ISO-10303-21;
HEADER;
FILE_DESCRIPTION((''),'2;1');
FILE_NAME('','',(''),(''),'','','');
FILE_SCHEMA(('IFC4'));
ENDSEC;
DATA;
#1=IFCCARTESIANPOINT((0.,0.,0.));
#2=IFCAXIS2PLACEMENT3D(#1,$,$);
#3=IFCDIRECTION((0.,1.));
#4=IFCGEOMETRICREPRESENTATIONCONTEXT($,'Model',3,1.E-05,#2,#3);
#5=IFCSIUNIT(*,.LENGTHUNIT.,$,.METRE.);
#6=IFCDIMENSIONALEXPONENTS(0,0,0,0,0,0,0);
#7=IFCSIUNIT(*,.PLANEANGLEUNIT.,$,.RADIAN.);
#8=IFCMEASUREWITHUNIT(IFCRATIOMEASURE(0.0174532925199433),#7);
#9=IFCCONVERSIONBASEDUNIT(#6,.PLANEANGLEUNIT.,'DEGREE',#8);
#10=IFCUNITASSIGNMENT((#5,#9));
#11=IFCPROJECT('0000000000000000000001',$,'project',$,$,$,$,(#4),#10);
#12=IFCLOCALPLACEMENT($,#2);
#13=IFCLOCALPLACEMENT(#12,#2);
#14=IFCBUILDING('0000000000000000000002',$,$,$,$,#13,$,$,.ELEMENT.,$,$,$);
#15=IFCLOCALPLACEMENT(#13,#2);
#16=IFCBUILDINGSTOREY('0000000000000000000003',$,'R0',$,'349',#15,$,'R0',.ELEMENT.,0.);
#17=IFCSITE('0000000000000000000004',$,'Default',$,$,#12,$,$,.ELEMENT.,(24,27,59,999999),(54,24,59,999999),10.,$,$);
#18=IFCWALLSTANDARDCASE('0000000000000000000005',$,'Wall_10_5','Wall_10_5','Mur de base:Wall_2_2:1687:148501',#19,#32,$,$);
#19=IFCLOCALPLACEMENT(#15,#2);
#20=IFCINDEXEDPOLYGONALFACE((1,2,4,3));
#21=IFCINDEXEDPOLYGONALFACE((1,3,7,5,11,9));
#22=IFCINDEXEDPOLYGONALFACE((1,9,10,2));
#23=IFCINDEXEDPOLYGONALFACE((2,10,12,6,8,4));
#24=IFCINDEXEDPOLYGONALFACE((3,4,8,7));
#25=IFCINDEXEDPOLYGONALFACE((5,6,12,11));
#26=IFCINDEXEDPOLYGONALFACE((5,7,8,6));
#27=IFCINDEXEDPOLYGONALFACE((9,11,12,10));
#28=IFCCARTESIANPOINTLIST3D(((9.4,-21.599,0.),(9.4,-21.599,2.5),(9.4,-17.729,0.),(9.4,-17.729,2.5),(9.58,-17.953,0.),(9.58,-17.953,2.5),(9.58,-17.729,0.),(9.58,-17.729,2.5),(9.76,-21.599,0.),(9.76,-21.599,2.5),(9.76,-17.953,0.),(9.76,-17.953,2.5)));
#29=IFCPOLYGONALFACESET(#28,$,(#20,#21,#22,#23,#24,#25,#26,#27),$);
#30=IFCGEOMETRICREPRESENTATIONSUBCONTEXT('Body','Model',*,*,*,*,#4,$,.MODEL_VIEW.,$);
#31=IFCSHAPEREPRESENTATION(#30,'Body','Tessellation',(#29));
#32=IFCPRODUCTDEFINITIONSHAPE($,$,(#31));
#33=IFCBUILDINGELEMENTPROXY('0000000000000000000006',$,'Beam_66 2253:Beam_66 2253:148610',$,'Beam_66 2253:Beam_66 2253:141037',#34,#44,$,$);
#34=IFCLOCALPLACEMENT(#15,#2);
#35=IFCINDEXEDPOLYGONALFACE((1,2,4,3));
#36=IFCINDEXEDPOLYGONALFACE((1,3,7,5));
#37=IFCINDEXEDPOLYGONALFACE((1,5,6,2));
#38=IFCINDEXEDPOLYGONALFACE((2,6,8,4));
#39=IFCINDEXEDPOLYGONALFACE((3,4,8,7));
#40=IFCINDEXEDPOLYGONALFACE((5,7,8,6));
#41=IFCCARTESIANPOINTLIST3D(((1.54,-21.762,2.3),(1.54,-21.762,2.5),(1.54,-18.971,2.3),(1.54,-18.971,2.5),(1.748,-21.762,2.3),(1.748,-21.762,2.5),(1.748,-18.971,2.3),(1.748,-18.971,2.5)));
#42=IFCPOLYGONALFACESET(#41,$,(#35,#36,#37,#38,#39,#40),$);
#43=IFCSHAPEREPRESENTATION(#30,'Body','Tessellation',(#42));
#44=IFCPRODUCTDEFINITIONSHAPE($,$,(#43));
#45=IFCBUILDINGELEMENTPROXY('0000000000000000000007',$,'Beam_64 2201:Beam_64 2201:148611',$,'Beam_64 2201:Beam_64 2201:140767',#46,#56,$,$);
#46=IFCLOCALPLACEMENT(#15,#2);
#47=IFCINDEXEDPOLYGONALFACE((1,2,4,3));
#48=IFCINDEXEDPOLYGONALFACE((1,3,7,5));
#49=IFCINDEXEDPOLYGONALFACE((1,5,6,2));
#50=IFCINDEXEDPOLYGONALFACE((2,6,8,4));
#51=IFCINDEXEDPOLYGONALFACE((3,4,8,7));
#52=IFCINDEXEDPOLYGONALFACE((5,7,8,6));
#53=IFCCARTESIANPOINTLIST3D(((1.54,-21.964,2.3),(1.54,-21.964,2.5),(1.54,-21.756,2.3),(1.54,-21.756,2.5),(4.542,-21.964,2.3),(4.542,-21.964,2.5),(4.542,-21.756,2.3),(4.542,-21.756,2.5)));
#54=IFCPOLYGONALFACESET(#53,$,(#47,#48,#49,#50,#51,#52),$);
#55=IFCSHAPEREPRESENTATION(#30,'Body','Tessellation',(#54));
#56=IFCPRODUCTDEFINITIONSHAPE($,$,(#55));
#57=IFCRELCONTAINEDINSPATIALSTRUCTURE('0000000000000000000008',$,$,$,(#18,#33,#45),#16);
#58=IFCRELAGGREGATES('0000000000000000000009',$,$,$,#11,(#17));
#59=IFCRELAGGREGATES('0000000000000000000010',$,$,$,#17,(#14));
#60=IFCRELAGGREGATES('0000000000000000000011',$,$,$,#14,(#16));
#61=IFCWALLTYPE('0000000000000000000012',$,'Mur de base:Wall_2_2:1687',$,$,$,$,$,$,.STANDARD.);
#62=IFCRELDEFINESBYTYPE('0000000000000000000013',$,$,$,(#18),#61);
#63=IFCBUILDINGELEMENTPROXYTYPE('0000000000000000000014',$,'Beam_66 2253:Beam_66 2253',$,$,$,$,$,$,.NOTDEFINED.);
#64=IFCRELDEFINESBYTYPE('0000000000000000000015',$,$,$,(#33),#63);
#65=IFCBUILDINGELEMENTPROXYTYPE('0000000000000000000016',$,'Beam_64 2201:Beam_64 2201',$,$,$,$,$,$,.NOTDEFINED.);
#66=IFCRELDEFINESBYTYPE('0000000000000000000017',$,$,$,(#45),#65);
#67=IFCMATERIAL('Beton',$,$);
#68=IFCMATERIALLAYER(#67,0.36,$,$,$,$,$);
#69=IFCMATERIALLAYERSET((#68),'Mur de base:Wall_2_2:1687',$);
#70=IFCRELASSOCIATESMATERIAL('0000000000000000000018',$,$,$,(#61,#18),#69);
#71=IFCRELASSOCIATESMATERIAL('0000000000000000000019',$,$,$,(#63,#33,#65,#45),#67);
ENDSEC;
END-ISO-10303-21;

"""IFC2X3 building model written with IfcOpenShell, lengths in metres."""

from ifc_helpers import new_model, entity, si_unit, converted_unit, direction, frame, origin, origin_2d_with_axis, place, context, subcontext, project, spatial, polyline, rectangle, outline, extrude, source, transform, mapped, material, layer, layer_set, layer_usage, type_object, type_shapes, element, save


model = new_model("IFC2X3")

# Units and contexts
model_context = context("Model", 3, precision=1e-05, world=origin(), true_north=direction((0.0, 1.0)))
body_context = subcontext(model_context, "Body", "Model", "MODEL_VIEW")
ifc_project = project(units=[si_unit("LENGTHUNIT", "METRE"), converted_unit("PLANEANGLEUNIT", "DEGREE", entity("IfcRatioMeasure", 0.0174532925199433), si_unit("PLANEANGLEUNIT", "RADIAN"), dimensions=[0, 0, 0, 0, 0, 0, 0])], contexts=[model_context])

# Site, building, storey
site_placement = place(None, origin())
site = spatial("IfcSite", under=ifc_project, at=site_placement, Name="Default", CompositionType="ELEMENT", RefLatitude=(24, 27, 59, 999999), RefLongitude=(54, 24, 59, 999999), RefElevation=10.0)
building_placement = place(site_placement, origin())
building = spatial("IfcBuilding", under=site, at=building_placement, CompositionType="ELEMENT")
storey_placement = place(building_placement, origin())
storey = spatial("IfcBuildingStorey", under=building, at=storey_placement, Name="R0", ObjectType="349", LongName="R0", CompositionType="ELEMENT", Elevation=0.0)

# Shared definitions
ifc_material_1 = material(Name="Beton")

# Shared definitions
ifc_layer_1 = layer(ifc_material_1, 0.36)
ifc_layer_set_1 = layer_set([ifc_layer_1], Name="Mur de base:Wall_2_2:1687")
wall_type_1 = type_object("IfcWallType", Name="Mur de base:Wall_2_2:1687", PredefinedType="STANDARD", material=ifc_layer_set_1)

# Wall
ifc_layer_usage_1 = layer_usage(ifc_layer_set_1, "AXIS2", "NEGATIVE", 0.18)
wall_1_placement = place(storey_placement, frame((9.58, -21.599, 0.0), z_axis=(0.0, 0.0, 1.0), x_axis=(0.0, 1.0, 0.0)))
element("IfcWallStandardCase", 1, at=wall_1_placement, inside=storey, type_object=wall_type_1, material=ifc_layer_usage_1, Name="Wall_10_5", Description="Wall_10_5", ObjectType="Mur de base:Wall_2_2:1687:148501", context=body_context, shape_type="SweptSolid", body=[
    extrude(outline(polyline([(3.646, -0.18), (3.646, 0.0), (3.87, 0.0), (3.87, 0.18), (0.0, 0.18), (0.0, -0.18), (3.646, -0.18)])), origin(), (0.0, 0.0, 1.0), 2.5),
])

# Building element proxies
building_element_proxy_type_1 = type_object("IfcBuildingElementProxyType", Name="Beam_66 2253:Beam_66 2253", PredefinedType="NOTDEFINED", material=ifc_material_1)
shared_shape_1 = source(origin(), body_context, "Body", "SweptSolid", [
    extrude(rectangle(XDim=0.208, YDim=2.791, at=origin_2d_with_axis()), frame((1.3955, 0.0, 0.0), z_axis=(0.0, 0.0, 1.0), x_axis=(0.0, 1.0, 0.0)), (0.0, 0.0, 1.0), 0.2),
])
type_shapes(building_element_proxy_type_1, [shared_shape_1])
proxy_1_placement = place(storey_placement, frame((1.644, -18.971, 2.3), z_axis=(0.0, 0.0, 1.0), x_axis=(0.0, -1.0, 0.0)))
element("IfcBuildingElementProxy", 2, at=proxy_1_placement, inside=storey, type_object=building_element_proxy_type_1, material=ifc_material_1, Name="Beam_66 2253:Beam_66 2253:148610", ObjectType="Beam_66 2253:Beam_66 2253:141037", context=body_context, shape_type="MappedRepresentation", body=[
    mapped(shared_shape_1, transform((0.0, 0.0, 0.0), scale=1.0)),
])
building_element_proxy_type_2 = type_object("IfcBuildingElementProxyType", Name="Beam_64 2201:Beam_64 2201", PredefinedType="NOTDEFINED", material=ifc_material_1)
shared_shape_2 = source(origin(), body_context, "Body", "SweptSolid", [
    extrude(rectangle(XDim=0.208, YDim=3.002, at=origin_2d_with_axis()), frame((1.501, 0.0, 0.0), z_axis=(0.0, 0.0, 1.0), x_axis=(0.0, 1.0, 0.0)), (0.0, 0.0, 1.0), 0.2),
])
type_shapes(building_element_proxy_type_2, [shared_shape_2])
proxy_2_placement = place(storey_placement, frame((1.54, -21.86, 2.3)))
element("IfcBuildingElementProxy", 3, at=proxy_2_placement, inside=storey, type_object=building_element_proxy_type_2, material=ifc_material_1, Name="Beam_64 2201:Beam_64 2201:148611", ObjectType="Beam_64 2201:Beam_64 2201:140767", context=body_context, shape_type="MappedRepresentation", body=[
    mapped(shared_shape_2, transform((0.0, 0.0, 0.0), scale=1.0)),
])

save(model, "model.ifc")
